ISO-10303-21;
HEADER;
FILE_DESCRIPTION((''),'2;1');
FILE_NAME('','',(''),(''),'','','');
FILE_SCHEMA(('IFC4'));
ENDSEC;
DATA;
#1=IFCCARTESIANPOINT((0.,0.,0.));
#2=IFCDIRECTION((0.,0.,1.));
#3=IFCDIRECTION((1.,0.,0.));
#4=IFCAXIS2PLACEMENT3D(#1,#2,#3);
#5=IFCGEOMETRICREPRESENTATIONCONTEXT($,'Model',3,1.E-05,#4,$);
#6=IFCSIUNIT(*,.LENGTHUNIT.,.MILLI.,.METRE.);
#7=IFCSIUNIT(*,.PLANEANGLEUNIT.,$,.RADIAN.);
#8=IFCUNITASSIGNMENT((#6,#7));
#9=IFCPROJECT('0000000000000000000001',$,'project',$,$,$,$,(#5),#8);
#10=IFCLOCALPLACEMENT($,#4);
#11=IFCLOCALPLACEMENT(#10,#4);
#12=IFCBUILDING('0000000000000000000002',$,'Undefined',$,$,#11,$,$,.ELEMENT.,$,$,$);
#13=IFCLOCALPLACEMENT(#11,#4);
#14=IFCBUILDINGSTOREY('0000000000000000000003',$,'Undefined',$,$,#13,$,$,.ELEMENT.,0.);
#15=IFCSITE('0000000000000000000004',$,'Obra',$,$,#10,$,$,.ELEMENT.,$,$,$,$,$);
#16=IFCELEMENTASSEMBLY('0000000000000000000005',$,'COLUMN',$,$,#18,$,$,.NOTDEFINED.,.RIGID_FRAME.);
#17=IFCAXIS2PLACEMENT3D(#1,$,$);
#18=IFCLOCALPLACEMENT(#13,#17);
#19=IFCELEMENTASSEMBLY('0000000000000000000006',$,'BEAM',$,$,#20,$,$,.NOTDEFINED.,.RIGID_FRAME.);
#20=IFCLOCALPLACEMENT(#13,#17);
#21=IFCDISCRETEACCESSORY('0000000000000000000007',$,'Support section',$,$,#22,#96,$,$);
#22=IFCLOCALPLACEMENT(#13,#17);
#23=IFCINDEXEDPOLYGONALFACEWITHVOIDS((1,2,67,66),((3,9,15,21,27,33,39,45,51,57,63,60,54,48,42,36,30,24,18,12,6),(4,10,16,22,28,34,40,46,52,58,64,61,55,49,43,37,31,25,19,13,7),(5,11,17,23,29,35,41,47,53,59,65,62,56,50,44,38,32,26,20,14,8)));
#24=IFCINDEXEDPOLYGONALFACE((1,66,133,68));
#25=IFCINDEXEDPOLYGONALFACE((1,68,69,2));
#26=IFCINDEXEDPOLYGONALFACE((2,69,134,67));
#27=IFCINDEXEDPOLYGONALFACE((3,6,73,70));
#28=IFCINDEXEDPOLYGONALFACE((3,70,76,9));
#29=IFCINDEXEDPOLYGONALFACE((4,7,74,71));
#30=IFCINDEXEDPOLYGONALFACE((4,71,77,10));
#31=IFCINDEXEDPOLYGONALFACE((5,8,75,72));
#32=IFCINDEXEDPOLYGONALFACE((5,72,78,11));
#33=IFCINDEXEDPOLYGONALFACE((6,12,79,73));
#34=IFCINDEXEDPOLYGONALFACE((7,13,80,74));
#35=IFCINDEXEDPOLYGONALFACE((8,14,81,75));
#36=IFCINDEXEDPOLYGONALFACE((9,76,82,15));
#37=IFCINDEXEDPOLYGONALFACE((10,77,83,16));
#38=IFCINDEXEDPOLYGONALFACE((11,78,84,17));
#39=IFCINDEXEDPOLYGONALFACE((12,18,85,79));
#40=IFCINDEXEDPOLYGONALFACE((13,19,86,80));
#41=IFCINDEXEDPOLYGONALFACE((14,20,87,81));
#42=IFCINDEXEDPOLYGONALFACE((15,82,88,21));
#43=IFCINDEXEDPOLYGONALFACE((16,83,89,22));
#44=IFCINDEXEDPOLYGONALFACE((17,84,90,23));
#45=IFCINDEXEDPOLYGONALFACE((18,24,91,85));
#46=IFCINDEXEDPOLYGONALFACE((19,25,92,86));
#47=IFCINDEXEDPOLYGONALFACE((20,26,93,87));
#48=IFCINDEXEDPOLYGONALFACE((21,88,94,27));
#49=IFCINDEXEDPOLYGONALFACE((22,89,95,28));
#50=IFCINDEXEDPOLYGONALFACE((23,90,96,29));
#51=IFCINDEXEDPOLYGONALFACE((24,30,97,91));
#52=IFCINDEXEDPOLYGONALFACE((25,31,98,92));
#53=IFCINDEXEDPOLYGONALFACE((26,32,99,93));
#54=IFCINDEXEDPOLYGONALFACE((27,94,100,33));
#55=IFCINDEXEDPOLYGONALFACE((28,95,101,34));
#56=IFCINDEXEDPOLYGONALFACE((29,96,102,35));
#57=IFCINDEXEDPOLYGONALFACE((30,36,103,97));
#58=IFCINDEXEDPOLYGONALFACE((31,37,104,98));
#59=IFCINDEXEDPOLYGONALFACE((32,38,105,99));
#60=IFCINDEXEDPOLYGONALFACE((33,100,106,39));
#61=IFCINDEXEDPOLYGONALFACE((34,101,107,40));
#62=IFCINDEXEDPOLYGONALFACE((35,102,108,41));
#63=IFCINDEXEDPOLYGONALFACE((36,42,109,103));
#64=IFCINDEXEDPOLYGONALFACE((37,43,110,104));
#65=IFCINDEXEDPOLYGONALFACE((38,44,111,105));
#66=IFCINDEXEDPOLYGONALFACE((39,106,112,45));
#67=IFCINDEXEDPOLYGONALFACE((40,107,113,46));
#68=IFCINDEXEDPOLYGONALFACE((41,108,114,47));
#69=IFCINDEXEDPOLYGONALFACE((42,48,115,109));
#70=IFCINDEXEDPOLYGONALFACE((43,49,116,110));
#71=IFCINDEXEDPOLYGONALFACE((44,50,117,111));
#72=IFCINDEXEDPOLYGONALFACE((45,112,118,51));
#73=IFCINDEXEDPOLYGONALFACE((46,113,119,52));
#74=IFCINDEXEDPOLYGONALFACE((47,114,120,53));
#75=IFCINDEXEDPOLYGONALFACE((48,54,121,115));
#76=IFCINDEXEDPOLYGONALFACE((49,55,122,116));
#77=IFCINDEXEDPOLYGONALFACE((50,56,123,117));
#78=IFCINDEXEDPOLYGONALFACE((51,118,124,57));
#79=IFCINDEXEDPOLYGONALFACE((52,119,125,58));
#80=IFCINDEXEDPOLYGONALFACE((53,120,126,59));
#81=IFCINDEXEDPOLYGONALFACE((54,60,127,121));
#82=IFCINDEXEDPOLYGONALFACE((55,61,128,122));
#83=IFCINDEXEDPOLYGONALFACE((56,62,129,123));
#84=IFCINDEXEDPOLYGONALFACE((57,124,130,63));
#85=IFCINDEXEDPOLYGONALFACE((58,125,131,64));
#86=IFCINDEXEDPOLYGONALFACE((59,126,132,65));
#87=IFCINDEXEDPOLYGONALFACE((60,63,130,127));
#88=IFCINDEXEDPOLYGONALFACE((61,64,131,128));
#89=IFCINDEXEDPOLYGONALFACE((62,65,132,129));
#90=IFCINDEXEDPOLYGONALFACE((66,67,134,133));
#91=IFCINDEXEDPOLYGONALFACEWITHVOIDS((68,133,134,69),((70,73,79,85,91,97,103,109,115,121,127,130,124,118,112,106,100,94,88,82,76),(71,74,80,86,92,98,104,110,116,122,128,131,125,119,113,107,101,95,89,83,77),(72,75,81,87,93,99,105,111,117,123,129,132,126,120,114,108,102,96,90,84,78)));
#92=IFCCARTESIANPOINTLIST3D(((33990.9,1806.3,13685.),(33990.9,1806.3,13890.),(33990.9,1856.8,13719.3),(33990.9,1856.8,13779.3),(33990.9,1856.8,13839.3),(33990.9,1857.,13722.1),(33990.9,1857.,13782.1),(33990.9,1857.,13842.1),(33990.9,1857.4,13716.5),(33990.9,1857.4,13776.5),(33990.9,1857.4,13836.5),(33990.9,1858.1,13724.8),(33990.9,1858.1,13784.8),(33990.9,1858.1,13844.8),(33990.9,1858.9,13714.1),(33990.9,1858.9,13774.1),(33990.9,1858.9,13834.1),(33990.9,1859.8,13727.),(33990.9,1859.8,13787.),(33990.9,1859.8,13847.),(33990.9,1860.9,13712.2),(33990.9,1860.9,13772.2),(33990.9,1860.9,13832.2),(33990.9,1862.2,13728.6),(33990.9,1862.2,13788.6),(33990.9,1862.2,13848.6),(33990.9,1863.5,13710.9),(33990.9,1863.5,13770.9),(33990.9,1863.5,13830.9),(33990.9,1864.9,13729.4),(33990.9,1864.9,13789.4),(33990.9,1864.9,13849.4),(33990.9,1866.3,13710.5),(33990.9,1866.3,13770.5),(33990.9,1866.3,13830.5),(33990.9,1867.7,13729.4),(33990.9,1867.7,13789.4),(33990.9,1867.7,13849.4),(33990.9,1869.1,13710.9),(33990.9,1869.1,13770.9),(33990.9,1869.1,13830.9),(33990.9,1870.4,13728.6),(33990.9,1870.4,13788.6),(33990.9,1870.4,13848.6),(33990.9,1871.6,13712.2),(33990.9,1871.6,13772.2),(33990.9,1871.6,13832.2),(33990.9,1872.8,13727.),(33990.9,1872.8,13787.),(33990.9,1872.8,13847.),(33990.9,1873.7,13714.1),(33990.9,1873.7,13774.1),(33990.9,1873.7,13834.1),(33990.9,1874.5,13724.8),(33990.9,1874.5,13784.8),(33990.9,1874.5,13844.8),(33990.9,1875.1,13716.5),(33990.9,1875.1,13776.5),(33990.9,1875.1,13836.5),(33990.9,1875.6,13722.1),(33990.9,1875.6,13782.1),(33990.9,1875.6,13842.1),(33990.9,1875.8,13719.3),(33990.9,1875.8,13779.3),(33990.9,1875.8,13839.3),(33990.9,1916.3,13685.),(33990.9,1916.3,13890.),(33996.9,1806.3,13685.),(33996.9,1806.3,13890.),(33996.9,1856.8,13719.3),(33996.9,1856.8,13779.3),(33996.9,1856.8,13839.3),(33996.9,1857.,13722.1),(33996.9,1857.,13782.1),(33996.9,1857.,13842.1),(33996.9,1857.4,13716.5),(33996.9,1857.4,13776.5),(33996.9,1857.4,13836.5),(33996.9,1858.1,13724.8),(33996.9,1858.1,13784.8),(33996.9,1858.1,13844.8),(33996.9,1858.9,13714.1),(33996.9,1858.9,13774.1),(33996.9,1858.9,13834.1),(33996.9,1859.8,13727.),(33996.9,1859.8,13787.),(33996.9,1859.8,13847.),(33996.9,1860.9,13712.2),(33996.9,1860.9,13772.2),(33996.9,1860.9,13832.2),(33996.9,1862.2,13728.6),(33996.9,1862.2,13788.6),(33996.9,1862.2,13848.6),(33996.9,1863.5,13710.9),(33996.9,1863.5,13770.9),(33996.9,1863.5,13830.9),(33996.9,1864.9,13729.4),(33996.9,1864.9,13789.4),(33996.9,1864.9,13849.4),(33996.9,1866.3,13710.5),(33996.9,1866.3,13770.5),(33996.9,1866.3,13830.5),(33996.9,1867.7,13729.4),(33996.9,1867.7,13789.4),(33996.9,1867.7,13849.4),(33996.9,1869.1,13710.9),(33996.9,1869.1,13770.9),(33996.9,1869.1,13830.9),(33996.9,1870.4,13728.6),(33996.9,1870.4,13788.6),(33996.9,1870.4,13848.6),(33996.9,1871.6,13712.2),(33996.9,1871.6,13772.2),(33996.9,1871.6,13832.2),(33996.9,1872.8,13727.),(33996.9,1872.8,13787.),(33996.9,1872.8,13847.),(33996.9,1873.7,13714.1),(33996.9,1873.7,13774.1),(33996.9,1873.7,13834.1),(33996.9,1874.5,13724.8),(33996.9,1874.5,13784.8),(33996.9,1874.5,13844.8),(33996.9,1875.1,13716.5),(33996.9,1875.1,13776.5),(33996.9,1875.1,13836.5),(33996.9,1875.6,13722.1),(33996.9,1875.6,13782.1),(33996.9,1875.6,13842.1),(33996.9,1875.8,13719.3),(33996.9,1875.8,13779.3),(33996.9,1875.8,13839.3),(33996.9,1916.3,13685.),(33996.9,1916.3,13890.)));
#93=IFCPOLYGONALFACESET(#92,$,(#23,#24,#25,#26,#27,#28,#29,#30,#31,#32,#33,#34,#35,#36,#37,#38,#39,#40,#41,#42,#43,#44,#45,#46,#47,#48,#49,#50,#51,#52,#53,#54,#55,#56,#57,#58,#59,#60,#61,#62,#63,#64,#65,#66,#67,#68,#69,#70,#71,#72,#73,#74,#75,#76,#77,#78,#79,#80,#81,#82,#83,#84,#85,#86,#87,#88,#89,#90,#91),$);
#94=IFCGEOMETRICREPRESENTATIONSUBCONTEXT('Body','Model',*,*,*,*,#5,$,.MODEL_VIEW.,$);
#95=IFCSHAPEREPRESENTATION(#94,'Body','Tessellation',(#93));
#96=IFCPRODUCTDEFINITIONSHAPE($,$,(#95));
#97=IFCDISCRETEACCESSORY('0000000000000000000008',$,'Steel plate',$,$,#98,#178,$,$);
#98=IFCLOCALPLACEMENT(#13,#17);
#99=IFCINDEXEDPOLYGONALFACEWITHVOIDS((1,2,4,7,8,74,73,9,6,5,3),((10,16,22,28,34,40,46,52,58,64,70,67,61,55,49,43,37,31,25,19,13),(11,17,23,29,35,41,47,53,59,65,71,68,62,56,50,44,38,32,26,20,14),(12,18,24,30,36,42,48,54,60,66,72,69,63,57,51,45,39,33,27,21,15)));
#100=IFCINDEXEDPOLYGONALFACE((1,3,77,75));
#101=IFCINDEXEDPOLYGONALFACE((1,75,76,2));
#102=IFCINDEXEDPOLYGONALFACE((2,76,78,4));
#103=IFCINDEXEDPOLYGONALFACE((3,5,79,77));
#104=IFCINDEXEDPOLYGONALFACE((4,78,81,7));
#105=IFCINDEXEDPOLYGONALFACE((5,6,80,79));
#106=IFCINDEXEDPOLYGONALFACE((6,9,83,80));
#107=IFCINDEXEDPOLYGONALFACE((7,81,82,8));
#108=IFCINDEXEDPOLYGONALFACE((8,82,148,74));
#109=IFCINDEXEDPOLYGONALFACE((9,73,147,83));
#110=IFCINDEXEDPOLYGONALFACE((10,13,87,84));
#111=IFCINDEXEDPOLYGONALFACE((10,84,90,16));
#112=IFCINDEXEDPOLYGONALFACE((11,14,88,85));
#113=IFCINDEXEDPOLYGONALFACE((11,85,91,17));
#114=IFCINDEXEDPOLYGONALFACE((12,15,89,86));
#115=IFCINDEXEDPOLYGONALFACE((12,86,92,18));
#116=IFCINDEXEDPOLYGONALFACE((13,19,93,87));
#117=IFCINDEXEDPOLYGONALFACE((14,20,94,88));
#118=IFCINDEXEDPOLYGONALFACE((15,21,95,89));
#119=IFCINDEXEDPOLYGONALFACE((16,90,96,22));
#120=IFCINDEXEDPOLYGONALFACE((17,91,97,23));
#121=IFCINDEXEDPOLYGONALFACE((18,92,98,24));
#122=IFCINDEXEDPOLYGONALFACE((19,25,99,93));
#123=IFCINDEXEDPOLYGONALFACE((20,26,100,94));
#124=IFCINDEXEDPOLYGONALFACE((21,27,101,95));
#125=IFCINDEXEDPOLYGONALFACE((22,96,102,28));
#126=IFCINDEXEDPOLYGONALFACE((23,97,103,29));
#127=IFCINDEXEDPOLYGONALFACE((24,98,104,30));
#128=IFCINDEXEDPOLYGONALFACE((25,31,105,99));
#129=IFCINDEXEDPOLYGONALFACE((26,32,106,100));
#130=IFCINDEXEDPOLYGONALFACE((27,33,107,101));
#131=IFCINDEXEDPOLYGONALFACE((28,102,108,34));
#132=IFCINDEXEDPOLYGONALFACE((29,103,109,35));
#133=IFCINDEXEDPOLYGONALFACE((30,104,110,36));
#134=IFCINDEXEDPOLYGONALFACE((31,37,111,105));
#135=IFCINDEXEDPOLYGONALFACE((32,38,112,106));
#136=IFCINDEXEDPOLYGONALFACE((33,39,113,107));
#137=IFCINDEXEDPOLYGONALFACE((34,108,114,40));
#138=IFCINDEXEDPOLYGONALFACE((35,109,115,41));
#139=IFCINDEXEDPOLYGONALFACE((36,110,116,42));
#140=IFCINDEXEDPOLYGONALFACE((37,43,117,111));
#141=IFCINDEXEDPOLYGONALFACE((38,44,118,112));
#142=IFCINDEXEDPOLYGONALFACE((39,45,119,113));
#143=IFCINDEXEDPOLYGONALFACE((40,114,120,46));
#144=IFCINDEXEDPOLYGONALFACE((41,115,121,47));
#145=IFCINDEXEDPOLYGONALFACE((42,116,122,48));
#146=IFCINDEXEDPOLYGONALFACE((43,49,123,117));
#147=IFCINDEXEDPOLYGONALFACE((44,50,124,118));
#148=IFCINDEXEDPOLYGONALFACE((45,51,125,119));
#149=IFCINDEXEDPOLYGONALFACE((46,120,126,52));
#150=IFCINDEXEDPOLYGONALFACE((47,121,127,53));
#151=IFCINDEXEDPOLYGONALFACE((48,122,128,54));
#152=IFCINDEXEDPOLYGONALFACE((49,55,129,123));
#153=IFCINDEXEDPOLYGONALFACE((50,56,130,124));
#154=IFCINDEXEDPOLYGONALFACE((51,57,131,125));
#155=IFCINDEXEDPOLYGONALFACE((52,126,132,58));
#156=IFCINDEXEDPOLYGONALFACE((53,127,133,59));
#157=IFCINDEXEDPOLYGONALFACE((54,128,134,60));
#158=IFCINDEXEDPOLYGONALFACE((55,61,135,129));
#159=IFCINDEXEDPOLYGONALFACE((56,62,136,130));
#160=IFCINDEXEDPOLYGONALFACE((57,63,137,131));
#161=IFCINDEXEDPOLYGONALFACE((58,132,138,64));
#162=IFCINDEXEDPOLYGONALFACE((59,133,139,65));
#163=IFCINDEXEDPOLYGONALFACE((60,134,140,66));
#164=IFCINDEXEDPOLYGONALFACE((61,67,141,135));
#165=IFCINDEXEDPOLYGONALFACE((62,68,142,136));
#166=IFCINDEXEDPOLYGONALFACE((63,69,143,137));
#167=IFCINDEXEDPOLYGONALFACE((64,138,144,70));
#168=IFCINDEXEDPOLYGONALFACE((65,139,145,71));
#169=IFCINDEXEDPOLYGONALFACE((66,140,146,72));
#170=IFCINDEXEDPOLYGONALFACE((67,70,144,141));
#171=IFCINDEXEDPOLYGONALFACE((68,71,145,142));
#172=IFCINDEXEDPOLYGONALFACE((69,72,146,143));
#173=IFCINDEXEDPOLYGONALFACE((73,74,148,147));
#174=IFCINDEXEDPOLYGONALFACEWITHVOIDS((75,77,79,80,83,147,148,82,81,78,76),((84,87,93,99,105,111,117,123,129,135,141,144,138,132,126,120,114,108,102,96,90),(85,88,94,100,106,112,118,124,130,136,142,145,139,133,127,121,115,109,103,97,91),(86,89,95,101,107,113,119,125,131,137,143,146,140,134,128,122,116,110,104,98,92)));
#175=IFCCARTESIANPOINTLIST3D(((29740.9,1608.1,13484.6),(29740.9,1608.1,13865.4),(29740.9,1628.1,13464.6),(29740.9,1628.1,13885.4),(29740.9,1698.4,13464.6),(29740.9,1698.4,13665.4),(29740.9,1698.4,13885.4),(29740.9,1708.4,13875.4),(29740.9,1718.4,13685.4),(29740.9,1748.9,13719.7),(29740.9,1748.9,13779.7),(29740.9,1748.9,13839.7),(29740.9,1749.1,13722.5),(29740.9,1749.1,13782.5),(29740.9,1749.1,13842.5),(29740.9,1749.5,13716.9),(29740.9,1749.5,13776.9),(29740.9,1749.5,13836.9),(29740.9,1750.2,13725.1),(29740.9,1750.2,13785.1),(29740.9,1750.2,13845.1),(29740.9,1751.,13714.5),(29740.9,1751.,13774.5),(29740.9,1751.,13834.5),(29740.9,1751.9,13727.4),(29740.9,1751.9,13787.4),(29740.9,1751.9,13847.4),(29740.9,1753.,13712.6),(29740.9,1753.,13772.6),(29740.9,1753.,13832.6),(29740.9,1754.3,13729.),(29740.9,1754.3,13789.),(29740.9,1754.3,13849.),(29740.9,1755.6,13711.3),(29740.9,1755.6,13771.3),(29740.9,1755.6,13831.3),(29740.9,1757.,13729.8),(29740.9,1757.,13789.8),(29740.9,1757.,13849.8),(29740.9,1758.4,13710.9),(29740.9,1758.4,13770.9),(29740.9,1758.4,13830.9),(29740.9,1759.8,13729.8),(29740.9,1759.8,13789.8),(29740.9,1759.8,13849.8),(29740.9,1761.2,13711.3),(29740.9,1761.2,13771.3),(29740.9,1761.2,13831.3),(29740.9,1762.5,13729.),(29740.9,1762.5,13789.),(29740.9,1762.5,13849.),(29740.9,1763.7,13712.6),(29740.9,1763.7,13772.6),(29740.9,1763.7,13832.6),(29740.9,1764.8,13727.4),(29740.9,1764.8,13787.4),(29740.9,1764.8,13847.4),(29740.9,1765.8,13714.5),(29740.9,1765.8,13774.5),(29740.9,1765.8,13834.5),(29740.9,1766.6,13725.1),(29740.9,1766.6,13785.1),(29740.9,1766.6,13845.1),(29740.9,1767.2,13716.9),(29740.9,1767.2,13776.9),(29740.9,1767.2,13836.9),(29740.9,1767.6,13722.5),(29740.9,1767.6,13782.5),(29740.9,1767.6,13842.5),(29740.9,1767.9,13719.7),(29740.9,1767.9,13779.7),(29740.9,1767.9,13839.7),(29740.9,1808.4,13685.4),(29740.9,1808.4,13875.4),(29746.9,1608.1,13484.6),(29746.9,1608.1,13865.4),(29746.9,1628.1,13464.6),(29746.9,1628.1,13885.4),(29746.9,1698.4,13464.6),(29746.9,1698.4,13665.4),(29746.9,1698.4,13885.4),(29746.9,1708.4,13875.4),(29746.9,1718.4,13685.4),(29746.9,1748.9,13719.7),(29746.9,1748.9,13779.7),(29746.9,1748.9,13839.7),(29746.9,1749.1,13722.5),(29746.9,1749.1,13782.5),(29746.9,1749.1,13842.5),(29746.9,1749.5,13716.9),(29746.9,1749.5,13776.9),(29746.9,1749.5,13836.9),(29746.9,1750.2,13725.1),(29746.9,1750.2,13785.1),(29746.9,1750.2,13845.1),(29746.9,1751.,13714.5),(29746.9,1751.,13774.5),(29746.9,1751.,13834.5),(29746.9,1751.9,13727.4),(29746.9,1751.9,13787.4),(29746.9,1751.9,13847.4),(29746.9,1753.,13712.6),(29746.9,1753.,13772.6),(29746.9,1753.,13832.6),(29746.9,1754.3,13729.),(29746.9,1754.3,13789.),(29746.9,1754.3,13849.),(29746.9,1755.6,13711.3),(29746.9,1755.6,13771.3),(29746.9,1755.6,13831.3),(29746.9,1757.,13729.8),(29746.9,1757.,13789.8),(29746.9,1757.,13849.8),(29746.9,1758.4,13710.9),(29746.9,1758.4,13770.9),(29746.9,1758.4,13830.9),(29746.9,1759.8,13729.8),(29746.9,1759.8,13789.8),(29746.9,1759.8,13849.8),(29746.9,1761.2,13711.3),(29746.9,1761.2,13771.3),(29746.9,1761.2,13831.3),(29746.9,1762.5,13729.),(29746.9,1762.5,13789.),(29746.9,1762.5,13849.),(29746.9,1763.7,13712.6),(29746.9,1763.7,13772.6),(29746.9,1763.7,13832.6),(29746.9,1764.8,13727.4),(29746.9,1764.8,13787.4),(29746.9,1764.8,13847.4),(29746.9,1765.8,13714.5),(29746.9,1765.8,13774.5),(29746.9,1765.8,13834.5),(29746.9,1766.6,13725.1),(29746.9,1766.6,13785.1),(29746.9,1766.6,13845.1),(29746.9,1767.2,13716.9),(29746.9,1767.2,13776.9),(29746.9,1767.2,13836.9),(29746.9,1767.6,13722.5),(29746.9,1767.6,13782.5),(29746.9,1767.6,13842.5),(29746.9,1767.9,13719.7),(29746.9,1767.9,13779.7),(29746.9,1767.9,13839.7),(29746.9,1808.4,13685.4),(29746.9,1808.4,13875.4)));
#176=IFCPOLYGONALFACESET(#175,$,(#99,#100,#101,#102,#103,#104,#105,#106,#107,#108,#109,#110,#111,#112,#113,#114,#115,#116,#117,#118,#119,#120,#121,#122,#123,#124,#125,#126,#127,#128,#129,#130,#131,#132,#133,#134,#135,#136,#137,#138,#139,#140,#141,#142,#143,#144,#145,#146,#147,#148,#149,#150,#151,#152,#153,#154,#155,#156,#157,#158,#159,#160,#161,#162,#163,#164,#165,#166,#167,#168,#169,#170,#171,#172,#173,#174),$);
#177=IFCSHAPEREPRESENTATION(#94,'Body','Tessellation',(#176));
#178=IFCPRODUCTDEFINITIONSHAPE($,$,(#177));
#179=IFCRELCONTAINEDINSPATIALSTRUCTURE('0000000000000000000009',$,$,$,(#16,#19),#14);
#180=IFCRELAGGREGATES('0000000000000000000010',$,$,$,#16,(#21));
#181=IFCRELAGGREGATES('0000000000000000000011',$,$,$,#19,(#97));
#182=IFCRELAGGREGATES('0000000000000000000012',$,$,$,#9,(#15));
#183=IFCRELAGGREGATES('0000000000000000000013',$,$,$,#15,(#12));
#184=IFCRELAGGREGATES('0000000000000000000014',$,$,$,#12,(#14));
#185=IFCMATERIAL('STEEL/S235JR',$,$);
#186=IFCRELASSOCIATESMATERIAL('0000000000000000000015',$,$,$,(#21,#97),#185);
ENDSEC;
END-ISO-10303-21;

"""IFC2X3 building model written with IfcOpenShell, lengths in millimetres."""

from ifc_helpers import new_model, si_unit, frame, origin_with_axes, origin_2d_with_axis, place, context, subcontext, project, spatial, polyline, rectangle, circle, outline, extrude, source, transform, mapped, material, element, aggregate, save


model = new_model("IFC2X3")

# Units and contexts
model_context = context("Model", 3, precision=1e-05, world=origin_with_axes())
body_context = subcontext(model_context, "Body", "Model", "MODEL_VIEW")
ifc_project = project(units=[si_unit("LENGTHUNIT", "METRE", prefix="MILLI"), si_unit("PLANEANGLEUNIT", "RADIAN")], contexts=[model_context])

# Site, building, storey
site_placement = place(None, origin_with_axes())
site = spatial("IfcSite", under=ifc_project, at=site_placement, Name="Obra", CompositionType="ELEMENT")
building_placement = place(site_placement, origin_with_axes())
building = spatial("IfcBuilding", under=site, at=building_placement, Name="Undefined", CompositionType="ELEMENT")
storey_placement = place(building_placement, origin_with_axes())
storey = spatial("IfcBuildingStorey", under=building, at=storey_placement, Name="Undefined", CompositionType="ELEMENT", Elevation=0.0)

# Shared definitions
ifc_material_1 = material(Name="STEEL/S235JR")

# Element assembly
assembly_1_placement = place(storey_placement, origin_with_axes())
assembly_1 = element("IfcElementAssembly", 1, at=assembly_1_placement, inside=storey, Name="COLUMN", AssemblyPlace="NOTDEFINED", PredefinedType="RIGID_FRAME")

# Element assembly
assembly_2_placement = place(storey_placement, origin_with_axes())
assembly_2 = element("IfcElementAssembly", 2, at=assembly_2_placement, inside=storey, Name="BEAM", AssemblyPlace="NOTDEFINED", PredefinedType="RIGID_FRAME")
shared_shape_1 = source(origin_with_axes(), body_context, "Body", "SweptSolid", [
    extrude(circle(Radius=9.5, at=origin_2d_with_axis()), frame((0.0, 3.0, 0.0), z_axis=(0.0, 1.0, 0.0), x_axis=(1.0, 0.0, 0.0)), (0.0, 0.0, 1.0), 6.2),
])

# Discrete accessories, openings
discrete_accessory_1_placement = place(assembly_1_placement, frame((33993.9, 1861.3, 13685.0), z_axis=(0.0, 0.0, 1.0), x_axis=(0.0, -1.0, 0.0)))
discrete_accessory_1 = element("IfcDiscreteAccessory", 3, at=discrete_accessory_1_placement, material=ifc_material_1, Name="Support section", context=body_context, shape_type="SweptSolid", body=[
    extrude(rectangle(XDim=6.0, YDim=110.0, at=origin_2d_with_axis()), frame((0.0, 0.0, 205.0), z_axis=(0.0, 0.0, -1.0), x_axis=(0.0, 1.0, 0.0)), (0.0, 0.0, 1.0), 205.0),
])
opening_1_placement = place(assembly_1_placement, frame((34000.0, 1816.3, 13900.0), z_axis=(0.0, 1.0, 0.0), x_axis=(0.0, 0.0, -1.0)))
element("IfcOpeningElement", 4, at=opening_1_placement, cuts=discrete_accessory_1, ObjectType="Opening", context=body_context, shape_type="MappedRepresentation", body=[
    mapped(shared_shape_1, transform((60.0, 0.0, 50.0))),
    mapped(shared_shape_1, transform((120.0, 0.0, 50.0))),
    mapped(shared_shape_1, transform((180.0, 0.0, 50.0))),
])
aggregate(assembly_1, [discrete_accessory_1])
discrete_accessory_2_placement = place(assembly_2_placement, frame((29743.9, 1608.1, 13484.6), z_axis=(1.0, 0.0, 0.0), x_axis=(-0.000001, 0.707107, -0.707107)))
discrete_accessory_2 = element("IfcDiscreteAccessory", 5, at=discrete_accessory_2_placement, material=ifc_material_1, Name="Steel plate", context=body_context, shape_type="SweptSolid", body=[
    extrude(outline(polyline([(0.0, 0.0), (28.3, 0.0), (78.0, 49.7), (-64.0, 191.7), (-64.0, 220.0), (-0.4, 283.6), (-134.7, 418.0), (-205.4, 347.3), (-219.6, 347.3), (-219.6, 347.3), (-269.3, 297.6), (-269.3, 269.3), (0.0, 0.0)])), frame((0.0, 0.0, -3.0), z_axis=(0.0, 0.0, 1.0), x_axis=(1.0, 0.0, 0.0)), (0.0, 0.0, 1.0), 6.0),
])
opening_2_placement = place(assembly_2_placement, frame((29750.0, 1708.4, 13875.4), z_axis=(0.0, 1.0, 0.0), x_axis=(0.0, 0.0, -1.0)))
element("IfcOpeningElement", 6, at=opening_2_placement, cuts=discrete_accessory_2, ObjectType="Opening", context=body_context, shape_type="MappedRepresentation", body=[
    mapped(shared_shape_1, transform((35.0, 0.0, 50.0))),
    mapped(shared_shape_1, transform((95.0, 0.0, 50.0))),
    mapped(shared_shape_1, transform((155.0, 0.0, 50.0))),
])
aggregate(assembly_2, [discrete_accessory_2])

save(model, "model.ifc")
